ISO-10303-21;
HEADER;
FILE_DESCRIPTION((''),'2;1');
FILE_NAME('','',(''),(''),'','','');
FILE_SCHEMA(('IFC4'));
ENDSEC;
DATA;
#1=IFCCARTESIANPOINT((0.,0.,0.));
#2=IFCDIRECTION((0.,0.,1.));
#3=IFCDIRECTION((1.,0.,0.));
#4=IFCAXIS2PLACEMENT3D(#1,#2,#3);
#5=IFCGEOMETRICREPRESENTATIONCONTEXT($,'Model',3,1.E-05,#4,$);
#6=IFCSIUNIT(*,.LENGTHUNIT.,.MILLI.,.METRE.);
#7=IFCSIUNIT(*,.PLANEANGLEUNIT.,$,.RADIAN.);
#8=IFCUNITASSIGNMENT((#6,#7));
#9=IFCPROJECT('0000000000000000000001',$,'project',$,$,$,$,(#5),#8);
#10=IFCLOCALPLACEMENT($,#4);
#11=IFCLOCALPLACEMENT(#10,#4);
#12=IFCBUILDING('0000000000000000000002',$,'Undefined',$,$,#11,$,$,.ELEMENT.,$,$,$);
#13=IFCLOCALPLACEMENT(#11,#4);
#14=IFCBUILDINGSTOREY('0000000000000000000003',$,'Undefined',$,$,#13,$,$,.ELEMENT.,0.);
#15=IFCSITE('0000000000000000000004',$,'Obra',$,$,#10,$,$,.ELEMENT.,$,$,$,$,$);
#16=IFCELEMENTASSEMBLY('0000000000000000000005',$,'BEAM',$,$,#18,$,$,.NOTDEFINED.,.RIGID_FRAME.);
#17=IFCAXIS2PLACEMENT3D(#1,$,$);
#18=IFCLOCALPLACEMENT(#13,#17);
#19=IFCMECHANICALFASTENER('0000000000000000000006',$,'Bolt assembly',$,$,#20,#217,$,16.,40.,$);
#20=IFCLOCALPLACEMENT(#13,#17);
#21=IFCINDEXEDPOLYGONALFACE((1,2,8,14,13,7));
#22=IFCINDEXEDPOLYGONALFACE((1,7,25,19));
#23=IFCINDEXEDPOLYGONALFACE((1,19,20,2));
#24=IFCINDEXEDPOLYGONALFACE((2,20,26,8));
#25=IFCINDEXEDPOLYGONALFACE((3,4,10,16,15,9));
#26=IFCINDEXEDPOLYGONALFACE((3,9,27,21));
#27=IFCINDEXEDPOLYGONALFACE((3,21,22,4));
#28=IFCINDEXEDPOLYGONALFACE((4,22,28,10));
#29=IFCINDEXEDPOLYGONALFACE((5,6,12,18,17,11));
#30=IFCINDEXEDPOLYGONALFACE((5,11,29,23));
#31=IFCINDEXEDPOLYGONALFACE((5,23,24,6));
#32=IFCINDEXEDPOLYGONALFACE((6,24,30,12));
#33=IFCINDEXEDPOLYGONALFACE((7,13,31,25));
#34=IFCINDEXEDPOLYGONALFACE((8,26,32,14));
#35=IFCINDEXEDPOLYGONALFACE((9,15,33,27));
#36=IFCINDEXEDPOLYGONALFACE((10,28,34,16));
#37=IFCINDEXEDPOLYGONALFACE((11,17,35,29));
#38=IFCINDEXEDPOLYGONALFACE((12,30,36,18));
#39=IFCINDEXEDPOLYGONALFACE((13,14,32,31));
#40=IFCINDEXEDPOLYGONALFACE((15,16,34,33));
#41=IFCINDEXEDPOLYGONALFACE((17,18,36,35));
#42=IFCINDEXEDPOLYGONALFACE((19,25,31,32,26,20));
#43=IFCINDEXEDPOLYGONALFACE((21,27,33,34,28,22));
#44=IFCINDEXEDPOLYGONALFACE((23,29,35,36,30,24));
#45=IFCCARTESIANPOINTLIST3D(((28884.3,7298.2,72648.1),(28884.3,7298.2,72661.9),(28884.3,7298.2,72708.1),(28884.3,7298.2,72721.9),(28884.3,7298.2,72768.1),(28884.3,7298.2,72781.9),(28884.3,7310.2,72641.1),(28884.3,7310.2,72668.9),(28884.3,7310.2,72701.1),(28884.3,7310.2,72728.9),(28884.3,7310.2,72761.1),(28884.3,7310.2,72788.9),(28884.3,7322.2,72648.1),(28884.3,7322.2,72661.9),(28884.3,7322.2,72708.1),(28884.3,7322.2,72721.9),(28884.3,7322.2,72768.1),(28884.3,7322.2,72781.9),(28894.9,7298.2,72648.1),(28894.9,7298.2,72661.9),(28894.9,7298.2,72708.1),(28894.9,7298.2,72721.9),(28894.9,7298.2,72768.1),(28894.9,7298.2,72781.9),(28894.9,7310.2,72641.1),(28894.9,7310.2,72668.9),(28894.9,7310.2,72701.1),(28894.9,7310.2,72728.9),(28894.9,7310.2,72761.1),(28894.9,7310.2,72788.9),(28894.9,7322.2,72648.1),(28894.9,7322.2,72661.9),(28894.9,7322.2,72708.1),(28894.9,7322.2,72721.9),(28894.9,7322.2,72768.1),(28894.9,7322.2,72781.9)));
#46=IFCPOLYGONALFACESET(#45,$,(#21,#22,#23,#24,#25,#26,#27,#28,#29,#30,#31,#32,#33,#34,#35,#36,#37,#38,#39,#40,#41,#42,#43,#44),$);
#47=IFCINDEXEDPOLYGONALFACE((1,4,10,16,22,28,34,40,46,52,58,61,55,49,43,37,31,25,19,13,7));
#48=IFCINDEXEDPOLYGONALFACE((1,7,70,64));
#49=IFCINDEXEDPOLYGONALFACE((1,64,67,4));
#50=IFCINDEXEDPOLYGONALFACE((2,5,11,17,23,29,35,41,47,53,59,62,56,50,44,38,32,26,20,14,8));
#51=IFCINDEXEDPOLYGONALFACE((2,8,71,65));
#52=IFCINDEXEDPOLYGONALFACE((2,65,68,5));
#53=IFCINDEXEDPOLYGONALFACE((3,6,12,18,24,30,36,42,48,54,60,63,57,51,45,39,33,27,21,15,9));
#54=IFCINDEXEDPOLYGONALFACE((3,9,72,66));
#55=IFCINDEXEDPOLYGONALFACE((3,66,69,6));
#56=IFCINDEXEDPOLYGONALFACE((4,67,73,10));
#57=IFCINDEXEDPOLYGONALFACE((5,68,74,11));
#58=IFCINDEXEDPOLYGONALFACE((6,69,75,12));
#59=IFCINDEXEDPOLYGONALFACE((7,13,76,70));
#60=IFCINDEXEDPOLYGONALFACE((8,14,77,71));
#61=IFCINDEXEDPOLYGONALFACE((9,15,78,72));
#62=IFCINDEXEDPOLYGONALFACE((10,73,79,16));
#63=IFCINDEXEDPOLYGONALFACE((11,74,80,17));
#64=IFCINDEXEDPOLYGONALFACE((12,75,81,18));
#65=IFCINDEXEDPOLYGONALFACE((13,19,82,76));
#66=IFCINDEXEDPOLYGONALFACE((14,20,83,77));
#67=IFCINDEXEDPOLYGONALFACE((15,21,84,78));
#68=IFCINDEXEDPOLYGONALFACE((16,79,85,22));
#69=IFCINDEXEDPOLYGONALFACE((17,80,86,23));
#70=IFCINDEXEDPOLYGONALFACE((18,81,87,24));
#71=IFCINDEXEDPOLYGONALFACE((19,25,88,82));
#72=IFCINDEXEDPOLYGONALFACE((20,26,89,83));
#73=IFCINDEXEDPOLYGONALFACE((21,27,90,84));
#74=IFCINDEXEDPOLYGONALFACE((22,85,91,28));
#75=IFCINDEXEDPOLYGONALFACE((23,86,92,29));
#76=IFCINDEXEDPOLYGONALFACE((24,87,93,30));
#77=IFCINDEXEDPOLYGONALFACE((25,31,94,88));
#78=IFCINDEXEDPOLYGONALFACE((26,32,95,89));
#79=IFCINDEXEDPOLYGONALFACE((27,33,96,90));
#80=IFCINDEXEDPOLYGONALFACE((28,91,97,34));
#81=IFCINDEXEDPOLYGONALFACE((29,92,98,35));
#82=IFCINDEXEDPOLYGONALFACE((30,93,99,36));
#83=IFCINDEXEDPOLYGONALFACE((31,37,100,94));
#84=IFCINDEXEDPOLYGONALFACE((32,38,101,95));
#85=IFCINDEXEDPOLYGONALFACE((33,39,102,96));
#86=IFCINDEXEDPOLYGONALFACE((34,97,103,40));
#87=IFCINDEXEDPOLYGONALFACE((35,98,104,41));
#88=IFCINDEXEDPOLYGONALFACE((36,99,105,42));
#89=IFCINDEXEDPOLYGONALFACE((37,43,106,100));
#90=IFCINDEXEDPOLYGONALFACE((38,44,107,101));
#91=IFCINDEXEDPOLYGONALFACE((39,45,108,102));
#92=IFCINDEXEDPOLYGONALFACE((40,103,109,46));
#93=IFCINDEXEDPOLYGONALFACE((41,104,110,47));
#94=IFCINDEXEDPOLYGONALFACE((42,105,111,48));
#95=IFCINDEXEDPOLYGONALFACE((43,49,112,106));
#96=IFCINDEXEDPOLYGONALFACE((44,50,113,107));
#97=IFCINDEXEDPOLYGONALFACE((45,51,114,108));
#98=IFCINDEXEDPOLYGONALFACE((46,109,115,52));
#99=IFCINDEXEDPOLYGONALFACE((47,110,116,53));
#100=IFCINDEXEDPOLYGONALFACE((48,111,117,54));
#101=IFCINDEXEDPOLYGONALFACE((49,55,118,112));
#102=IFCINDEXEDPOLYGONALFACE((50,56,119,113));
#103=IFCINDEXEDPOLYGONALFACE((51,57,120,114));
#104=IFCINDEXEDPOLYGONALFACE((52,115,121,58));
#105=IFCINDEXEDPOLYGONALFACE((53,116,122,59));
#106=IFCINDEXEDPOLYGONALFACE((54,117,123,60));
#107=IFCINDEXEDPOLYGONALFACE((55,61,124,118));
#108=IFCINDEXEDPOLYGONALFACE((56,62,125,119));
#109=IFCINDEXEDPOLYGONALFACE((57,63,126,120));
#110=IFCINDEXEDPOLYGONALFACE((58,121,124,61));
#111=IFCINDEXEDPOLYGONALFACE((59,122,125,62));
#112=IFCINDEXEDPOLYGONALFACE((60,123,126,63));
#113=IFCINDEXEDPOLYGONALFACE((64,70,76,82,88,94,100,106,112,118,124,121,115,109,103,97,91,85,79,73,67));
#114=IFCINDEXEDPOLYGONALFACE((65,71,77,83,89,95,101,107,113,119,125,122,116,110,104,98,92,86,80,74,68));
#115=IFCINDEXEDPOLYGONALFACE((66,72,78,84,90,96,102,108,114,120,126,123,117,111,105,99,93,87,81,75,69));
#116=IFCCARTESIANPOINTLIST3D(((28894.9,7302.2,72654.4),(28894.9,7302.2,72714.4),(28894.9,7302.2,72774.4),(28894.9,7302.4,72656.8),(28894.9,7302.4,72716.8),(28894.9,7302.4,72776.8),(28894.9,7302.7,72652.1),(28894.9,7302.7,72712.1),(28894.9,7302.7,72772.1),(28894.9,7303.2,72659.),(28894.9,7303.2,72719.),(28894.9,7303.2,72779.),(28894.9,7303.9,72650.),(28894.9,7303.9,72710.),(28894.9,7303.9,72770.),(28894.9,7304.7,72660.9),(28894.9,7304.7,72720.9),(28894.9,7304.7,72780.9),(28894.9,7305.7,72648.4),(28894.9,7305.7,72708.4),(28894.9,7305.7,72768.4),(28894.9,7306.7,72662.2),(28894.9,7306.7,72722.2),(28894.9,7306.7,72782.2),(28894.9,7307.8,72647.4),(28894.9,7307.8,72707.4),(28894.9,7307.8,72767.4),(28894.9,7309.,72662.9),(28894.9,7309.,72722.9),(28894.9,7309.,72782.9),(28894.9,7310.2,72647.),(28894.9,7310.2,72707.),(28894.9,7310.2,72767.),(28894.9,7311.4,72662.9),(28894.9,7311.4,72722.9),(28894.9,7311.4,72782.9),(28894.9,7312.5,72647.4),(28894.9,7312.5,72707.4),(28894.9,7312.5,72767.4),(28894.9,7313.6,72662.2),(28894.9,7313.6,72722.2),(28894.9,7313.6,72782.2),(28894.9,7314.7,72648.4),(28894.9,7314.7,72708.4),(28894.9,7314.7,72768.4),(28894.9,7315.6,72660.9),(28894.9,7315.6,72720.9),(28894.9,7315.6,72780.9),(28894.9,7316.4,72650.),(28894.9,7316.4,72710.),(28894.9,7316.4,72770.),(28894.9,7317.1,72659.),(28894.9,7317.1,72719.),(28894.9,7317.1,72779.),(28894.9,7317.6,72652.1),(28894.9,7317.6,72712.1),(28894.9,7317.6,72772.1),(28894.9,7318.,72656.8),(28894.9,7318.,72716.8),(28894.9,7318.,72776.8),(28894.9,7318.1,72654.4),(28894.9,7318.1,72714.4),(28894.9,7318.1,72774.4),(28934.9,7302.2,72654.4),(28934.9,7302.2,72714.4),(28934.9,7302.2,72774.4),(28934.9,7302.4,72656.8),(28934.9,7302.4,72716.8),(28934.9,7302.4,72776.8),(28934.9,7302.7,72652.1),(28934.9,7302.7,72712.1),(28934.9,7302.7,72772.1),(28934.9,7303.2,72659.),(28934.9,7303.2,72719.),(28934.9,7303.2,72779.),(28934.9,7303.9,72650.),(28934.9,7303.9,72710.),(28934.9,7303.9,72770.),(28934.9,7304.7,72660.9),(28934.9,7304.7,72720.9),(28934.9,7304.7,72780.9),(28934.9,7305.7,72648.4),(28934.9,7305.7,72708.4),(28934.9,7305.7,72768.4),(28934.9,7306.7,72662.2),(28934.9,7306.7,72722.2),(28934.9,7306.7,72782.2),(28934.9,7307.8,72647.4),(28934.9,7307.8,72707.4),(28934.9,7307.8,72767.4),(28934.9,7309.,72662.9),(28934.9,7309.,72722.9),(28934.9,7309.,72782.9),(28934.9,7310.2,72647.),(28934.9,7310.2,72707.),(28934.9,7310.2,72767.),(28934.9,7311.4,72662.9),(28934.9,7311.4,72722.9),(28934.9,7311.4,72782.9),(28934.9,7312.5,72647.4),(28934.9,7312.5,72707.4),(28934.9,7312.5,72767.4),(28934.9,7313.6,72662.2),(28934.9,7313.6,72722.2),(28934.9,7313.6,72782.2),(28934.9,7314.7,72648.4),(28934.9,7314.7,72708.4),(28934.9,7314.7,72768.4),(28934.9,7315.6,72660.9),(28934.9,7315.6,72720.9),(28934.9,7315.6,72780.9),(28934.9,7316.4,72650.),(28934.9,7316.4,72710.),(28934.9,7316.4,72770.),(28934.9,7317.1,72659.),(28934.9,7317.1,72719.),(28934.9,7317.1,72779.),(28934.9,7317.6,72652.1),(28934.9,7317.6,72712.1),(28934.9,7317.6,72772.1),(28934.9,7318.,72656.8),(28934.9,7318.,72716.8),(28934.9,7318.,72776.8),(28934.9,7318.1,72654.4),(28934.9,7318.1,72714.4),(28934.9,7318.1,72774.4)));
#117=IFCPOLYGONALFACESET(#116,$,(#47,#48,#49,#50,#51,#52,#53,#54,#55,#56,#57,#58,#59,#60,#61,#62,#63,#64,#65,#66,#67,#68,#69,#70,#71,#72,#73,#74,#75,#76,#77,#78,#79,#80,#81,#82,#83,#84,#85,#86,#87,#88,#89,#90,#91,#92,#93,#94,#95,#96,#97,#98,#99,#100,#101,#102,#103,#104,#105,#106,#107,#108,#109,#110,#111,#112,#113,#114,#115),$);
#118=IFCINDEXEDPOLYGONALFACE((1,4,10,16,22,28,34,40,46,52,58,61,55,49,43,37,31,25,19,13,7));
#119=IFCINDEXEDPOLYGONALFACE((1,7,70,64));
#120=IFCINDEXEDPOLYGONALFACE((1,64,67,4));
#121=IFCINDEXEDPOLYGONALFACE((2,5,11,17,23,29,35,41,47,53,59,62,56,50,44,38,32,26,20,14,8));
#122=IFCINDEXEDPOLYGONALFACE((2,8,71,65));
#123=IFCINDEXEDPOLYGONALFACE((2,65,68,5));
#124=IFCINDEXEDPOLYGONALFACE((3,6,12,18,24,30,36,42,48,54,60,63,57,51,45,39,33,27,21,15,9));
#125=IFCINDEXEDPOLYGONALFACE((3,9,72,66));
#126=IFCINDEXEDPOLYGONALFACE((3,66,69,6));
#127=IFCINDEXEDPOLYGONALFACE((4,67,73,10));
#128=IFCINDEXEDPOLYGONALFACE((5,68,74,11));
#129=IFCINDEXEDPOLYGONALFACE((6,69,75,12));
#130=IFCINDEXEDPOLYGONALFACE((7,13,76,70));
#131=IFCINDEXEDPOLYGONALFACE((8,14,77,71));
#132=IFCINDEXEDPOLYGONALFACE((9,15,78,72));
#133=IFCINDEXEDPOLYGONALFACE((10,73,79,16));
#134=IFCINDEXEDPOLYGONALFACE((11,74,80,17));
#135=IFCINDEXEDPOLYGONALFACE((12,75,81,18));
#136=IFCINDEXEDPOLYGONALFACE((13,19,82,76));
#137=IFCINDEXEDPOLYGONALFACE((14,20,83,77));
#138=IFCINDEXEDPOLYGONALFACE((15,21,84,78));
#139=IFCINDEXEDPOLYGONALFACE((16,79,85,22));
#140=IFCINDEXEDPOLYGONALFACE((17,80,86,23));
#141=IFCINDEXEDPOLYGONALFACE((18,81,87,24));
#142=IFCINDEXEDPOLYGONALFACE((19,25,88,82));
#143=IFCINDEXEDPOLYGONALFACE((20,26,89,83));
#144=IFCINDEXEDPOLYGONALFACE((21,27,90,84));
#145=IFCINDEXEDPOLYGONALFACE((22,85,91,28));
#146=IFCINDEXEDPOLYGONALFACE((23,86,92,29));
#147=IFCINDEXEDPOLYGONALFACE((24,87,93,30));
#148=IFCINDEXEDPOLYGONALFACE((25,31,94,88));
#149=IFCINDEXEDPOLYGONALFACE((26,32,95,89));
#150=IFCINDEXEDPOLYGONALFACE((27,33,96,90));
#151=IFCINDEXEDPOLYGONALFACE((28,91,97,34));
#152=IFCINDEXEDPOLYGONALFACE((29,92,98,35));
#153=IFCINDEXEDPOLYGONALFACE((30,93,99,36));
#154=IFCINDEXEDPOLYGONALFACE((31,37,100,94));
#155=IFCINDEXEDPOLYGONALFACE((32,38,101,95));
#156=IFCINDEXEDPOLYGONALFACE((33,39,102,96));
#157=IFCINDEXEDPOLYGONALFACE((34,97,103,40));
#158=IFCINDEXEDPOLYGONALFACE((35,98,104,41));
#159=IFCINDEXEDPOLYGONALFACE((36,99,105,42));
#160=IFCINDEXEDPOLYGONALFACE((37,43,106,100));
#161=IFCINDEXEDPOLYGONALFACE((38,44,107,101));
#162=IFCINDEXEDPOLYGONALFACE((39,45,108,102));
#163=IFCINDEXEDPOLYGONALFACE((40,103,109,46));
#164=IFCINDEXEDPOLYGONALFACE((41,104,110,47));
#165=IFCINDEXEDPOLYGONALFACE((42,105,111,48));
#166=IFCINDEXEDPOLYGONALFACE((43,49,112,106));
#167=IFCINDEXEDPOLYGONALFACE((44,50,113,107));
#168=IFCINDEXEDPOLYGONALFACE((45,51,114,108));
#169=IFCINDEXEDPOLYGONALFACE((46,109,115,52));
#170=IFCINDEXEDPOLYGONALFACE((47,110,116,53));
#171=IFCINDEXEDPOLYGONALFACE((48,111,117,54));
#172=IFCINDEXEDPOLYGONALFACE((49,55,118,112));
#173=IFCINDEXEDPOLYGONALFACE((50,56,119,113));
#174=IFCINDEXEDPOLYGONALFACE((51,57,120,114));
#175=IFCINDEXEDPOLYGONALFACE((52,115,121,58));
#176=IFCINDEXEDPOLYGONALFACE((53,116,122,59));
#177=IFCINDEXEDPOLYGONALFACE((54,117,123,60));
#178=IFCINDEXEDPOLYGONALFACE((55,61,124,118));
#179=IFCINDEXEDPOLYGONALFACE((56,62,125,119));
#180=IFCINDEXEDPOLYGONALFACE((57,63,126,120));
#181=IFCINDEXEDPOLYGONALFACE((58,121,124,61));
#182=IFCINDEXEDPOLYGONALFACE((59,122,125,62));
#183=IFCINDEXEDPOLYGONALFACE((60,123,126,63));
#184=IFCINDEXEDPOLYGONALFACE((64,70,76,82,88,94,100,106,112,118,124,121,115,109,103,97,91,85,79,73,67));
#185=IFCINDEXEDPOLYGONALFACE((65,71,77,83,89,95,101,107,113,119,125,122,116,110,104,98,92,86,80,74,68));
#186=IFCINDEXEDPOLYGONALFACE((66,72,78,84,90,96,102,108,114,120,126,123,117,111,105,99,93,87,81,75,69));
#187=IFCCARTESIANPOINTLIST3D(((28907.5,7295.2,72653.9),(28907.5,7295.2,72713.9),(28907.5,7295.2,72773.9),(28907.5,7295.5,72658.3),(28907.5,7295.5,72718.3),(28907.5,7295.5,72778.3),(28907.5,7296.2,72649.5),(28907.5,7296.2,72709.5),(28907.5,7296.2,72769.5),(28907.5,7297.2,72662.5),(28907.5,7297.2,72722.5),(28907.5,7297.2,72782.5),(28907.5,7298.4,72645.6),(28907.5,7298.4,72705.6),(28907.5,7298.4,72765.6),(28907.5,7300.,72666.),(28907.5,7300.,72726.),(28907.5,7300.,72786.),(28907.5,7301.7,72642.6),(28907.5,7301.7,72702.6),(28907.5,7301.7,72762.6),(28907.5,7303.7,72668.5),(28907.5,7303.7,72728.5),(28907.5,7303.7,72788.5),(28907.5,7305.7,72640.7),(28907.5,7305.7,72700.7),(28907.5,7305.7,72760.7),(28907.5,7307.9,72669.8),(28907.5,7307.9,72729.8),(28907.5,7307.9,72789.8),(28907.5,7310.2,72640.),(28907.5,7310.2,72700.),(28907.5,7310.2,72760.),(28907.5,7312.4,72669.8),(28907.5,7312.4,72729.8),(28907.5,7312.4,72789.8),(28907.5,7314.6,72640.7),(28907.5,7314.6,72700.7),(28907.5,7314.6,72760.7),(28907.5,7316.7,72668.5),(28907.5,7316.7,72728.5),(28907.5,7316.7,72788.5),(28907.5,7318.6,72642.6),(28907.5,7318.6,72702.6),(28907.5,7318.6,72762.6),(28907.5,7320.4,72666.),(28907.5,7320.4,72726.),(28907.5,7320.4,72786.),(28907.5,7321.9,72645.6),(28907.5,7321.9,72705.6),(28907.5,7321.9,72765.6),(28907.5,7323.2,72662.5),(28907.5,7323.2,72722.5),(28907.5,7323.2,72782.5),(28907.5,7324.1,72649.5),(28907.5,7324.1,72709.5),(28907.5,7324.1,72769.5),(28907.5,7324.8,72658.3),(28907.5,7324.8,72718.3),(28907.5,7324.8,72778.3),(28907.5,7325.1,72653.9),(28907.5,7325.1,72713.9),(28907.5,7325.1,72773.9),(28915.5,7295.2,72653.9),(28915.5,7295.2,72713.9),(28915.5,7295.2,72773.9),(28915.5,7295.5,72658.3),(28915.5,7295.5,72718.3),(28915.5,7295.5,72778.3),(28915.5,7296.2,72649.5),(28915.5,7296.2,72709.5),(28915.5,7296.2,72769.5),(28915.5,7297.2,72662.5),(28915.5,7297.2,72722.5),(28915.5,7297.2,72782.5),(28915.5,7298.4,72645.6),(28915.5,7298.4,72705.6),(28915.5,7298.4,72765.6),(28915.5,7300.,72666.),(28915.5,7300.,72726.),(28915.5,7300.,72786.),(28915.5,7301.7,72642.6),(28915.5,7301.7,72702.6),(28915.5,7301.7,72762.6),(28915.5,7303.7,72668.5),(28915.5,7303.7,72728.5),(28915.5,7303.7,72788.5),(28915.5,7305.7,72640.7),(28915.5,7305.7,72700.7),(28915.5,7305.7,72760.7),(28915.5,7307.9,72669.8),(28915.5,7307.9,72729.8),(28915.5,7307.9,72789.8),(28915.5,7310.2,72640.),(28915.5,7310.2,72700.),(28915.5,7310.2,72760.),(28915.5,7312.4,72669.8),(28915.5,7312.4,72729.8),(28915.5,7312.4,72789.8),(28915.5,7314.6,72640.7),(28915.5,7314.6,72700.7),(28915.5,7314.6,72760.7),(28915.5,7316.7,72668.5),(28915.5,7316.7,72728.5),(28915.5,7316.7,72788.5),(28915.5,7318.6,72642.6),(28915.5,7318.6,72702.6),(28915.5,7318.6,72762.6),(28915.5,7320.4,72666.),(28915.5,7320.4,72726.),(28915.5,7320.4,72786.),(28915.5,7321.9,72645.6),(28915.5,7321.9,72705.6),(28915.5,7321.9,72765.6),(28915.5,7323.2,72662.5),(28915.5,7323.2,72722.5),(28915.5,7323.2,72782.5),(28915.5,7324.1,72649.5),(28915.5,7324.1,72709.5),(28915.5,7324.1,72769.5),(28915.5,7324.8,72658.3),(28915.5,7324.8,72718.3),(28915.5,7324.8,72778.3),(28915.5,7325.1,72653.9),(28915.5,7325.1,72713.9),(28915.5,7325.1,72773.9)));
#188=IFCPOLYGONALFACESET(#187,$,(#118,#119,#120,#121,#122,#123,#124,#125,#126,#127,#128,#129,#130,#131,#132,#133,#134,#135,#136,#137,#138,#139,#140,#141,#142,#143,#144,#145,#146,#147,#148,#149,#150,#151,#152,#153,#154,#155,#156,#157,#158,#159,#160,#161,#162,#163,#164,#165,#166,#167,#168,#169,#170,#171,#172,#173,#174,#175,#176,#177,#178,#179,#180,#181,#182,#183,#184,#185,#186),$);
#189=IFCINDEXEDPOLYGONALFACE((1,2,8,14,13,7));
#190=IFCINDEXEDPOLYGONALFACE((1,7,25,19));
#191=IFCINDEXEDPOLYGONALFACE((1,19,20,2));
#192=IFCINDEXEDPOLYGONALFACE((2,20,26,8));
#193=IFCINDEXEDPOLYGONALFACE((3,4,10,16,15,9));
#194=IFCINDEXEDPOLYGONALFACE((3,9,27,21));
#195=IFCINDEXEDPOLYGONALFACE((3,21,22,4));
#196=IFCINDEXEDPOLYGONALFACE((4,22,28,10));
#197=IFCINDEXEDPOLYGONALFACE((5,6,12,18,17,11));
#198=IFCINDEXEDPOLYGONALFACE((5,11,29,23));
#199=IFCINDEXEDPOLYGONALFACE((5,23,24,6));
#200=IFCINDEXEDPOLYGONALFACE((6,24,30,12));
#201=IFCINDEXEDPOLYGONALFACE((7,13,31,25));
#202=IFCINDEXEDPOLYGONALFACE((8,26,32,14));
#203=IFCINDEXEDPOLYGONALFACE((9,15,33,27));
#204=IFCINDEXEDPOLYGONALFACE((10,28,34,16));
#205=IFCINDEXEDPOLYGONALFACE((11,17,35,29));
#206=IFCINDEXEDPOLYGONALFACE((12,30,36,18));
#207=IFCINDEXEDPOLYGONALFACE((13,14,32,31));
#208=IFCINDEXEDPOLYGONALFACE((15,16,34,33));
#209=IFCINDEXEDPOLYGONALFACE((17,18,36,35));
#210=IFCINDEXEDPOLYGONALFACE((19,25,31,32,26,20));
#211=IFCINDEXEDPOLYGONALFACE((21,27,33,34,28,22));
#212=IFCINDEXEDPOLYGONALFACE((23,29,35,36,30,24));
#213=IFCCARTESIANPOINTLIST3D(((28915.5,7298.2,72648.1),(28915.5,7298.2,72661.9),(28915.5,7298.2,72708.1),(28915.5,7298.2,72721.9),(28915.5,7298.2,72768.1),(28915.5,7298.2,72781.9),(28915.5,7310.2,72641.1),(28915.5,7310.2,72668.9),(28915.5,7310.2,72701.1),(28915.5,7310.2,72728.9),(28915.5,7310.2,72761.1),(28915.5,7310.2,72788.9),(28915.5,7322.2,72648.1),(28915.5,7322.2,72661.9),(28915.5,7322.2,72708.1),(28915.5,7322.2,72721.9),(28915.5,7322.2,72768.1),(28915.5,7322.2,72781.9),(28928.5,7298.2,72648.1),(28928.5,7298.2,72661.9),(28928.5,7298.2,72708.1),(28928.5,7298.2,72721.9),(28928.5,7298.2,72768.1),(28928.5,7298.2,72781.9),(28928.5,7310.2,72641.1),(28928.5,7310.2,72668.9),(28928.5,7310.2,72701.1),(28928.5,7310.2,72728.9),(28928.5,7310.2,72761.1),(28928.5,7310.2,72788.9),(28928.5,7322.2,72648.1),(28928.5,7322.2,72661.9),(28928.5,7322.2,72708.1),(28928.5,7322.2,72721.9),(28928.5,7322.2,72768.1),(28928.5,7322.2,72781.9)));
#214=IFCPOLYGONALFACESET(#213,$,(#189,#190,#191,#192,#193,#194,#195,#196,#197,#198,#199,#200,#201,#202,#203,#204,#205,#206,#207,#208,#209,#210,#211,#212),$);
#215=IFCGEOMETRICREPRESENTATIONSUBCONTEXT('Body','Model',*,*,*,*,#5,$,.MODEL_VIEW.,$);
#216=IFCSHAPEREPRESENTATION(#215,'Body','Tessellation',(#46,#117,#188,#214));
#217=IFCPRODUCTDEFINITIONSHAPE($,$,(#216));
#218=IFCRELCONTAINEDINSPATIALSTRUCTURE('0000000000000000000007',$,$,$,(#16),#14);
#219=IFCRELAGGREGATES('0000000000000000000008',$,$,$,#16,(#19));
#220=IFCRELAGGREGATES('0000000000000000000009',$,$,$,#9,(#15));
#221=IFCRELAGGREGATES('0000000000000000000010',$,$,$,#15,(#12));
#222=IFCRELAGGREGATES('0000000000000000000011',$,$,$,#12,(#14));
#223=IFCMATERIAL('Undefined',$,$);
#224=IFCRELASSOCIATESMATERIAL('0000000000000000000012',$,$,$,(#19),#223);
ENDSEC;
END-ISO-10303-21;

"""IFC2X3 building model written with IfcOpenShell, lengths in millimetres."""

from ifc_helpers import new_model, si_unit, frame, origin_with_axes, origin_2d_with_axis, place, context, subcontext, project, spatial, polyline, circle, outline, extrude, source, transform, mapped, material, element, aggregate, save


model = new_model("IFC2X3")

# Units and contexts
model_context = context("Model", 3, precision=1e-05, world=origin_with_axes())
body_context = subcontext(model_context, "Body", "Model", "MODEL_VIEW")
ifc_project = project(units=[si_unit("LENGTHUNIT", "METRE", prefix="MILLI"), si_unit("PLANEANGLEUNIT", "RADIAN")], contexts=[model_context])

# Site, building, storey
site_placement = place(None, origin_with_axes())
site = spatial("IfcSite", under=ifc_project, at=site_placement, Name="Obra", CompositionType="ELEMENT")
building_placement = place(site_placement, origin_with_axes())
building = spatial("IfcBuilding", under=site, at=building_placement, Name="Undefined", CompositionType="ELEMENT")
storey_placement = place(building_placement, origin_with_axes())
storey = spatial("IfcBuildingStorey", under=building, at=storey_placement, Name="Undefined", CompositionType="ELEMENT", Elevation=0.0)

# Element assembly, mechanical fastener
ifc_material = material(Name="Undefined")
assembly_1_placement = place(storey_placement, origin_with_axes())
assembly_1 = element("IfcElementAssembly", 1, at=assembly_1_placement, inside=storey, Name="BEAM", AssemblyPlace="NOTDEFINED", PredefinedType="RIGID_FRAME")
shared_shape_1 = source(origin_with_axes(), body_context, "Body", "SweptSolid", [
    extrude(outline(polyline([(13.9, 0.0), (6.9, 12.0), (-6.9, 12.0), (-13.9, 0.0), (-6.9, -12.0), (6.9, -12.0), (13.9, 0.0)])), frame((0.0, -19.7, 0.0), z_axis=(0.0, 1.0, 0.0), x_axis=(1.0, 0.0, 0.0)), (0.0, 0.0, 1.0), 10.6),
    extrude(circle(Radius=8.0, at=origin_2d_with_axis()), frame((0.0, -9.1, 0.0), z_axis=(0.0, 1.0, 0.0), x_axis=(1.0, 0.0, 0.0)), (0.0, 0.0, 1.0), 40.0),
    extrude(circle(Radius=15.0, at=origin_2d_with_axis()), frame((0.0, 3.5, 0.0), z_axis=(0.0, 1.0, 0.0), x_axis=(1.0, 0.0, 0.0)), (0.0, 0.0, 1.0), 8.0),
    extrude(outline(polyline([(13.9, 0.0), (6.9, 12.0), (-6.9, 12.0), (-13.9, 0.0), (-6.9, -12.0), (6.9, -12.0), (13.9, 0.0)])), frame((0.0, 11.5, 0.0), z_axis=(0.0, 1.0, 0.0), x_axis=(1.0, 0.0, 0.0)), (0.0, 0.0, 1.0), 13.0),
])
mechanical_fastener_1_placement = place(assembly_1_placement, frame((28904.0, 7360.2, 72835.0), z_axis=(0.000005, -1.0, 0.0), x_axis=(0.0, 0.0, -1.0)))
mechanical_fastener_1 = element("IfcMechanicalFastener", 2, at=mechanical_fastener_1_placement, material=ifc_material, Name="Bolt assembly", NominalDiameter=16.0, NominalLength=40.0, context=body_context, shape_type="MappedRepresentation", body=[
    mapped(shared_shape_1, transform((60.0, 0.0, 50.0))),
    mapped(shared_shape_1, transform((120.0, 0.0, 50.0))),
    mapped(shared_shape_1, transform((180.0, 0.0, 50.0))),
])
aggregate(assembly_1, [mechanical_fastener_1])

save(model, "model.ifc")
